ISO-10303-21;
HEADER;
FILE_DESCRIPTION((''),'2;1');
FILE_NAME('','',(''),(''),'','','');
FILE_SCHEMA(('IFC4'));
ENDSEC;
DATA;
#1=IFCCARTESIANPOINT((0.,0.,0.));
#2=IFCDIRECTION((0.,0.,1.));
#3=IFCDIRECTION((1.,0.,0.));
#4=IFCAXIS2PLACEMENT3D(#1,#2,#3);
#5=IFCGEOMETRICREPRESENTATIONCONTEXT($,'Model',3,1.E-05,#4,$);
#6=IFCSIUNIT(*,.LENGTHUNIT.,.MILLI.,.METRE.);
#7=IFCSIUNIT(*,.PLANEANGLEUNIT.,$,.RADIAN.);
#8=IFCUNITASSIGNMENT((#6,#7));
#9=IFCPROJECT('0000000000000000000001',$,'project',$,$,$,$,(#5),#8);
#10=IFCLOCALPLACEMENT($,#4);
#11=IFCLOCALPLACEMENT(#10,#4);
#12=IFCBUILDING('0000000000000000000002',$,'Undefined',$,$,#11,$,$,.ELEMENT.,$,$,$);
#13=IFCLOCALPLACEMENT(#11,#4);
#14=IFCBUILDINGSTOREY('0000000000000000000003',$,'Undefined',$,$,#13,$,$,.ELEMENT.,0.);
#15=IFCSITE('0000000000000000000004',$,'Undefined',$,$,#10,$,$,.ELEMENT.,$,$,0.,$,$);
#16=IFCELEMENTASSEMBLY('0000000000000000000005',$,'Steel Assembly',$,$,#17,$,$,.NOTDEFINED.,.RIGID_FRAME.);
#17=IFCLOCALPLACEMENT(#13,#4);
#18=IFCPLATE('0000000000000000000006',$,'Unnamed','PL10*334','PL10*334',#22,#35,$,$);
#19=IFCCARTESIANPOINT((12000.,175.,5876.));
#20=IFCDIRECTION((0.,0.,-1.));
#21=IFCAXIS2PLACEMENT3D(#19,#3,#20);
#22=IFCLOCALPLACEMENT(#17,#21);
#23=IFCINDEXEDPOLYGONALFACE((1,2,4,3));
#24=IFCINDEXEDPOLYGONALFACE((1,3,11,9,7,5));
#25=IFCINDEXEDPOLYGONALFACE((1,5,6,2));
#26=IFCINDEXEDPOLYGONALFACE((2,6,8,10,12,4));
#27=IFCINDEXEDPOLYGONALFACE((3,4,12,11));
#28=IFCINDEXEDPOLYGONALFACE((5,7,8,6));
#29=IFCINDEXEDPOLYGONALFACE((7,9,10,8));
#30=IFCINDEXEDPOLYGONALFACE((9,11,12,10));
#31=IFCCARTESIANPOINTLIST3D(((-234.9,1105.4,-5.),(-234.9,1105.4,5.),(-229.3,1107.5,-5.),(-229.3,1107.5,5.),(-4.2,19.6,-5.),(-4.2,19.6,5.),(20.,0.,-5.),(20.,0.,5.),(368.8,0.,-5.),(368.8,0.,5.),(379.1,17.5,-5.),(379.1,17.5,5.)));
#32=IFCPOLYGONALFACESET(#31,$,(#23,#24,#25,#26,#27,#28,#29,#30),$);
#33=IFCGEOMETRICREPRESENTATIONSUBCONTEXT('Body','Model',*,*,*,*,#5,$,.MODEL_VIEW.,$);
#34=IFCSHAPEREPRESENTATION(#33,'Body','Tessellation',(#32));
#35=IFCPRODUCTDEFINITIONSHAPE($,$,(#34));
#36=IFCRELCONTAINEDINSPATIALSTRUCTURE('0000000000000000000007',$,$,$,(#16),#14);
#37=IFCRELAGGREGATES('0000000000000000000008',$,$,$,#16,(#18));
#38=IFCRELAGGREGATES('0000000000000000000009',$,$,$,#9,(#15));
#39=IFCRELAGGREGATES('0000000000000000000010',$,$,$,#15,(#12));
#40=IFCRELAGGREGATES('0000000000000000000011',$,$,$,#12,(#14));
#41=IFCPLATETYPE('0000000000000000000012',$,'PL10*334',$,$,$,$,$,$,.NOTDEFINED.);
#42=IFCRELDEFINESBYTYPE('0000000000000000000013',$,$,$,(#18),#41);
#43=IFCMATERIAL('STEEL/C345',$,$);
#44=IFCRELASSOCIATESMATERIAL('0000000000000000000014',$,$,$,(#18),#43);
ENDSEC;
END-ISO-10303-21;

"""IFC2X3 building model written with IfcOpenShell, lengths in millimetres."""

from ifc_helpers import new_model, si_unit, frame, origin_with_axes, place, context, subcontext, project, spatial, polyline, outline, extrude, material, type_object, element, aggregate, save


model = new_model("IFC2X3")

# Units and contexts
model_context = context("Model", 3, precision=1e-05, world=origin_with_axes())
body_context = subcontext(model_context, "Body", "Model", "MODEL_VIEW")
ifc_project = project(units=[si_unit("LENGTHUNIT", "METRE", prefix="MILLI"), si_unit("PLANEANGLEUNIT", "RADIAN")], contexts=[model_context])

# Site, building, storey
site_placement = place(None, origin_with_axes())
site = spatial("IfcSite", under=ifc_project, at=site_placement, Name="Undefined", CompositionType="ELEMENT", RefElevation=0.0)
building_placement = place(site_placement, origin_with_axes())
building = spatial("IfcBuilding", under=site, at=building_placement, Name="Undefined", CompositionType="ELEMENT")
storey_placement = place(building_placement, origin_with_axes())
storey = spatial("IfcBuildingStorey", under=building, at=storey_placement, Name="Undefined", CompositionType="ELEMENT", Elevation=0.0)

# Shared definitions
ifc_material = material(Name="STEEL/C345")

# Element assembly, plate
assembly_1_placement = place(storey_placement, origin_with_axes())
assembly_1 = element("IfcElementAssembly", 1, at=assembly_1_placement, inside=storey, Name="Steel Assembly", AssemblyPlace="NOTDEFINED", PredefinedType="RIGID_FRAME")
plate_type_1 = type_object("IfcPlateType", Name="PL10*334", PredefinedType="NOTDEFINED")
plate_1_placement = place(assembly_1_placement, frame((12000.0, 175.0, 5876.0), z_axis=(1.0, 0.0, 0.0), x_axis=(0.0, 0.0, -1.0)))
plate_1 = element("IfcPlate", 2, at=plate_1_placement, type_object=plate_type_1, material=ifc_material, Name="Unnamed", Description="PL10*334", ObjectType="PL10*334", context=body_context, shape_type="SweptSolid", body=[
    extrude(outline(polyline([(-4.2, 19.6), (20.0, 0.0), (368.8, 0.0), (379.1, 17.5), (-229.3, 1107.5), (-234.9, 1105.4), (-4.2, 19.6)])), frame((0.0, 0.0, -5.0), z_axis=(0.0, 0.0, 1.0), x_axis=(1.0, 0.0, 0.0)), (0.0, 0.0, 1.0), 10.0),
])
aggregate(assembly_1, [plate_1])

save(model, "model.ifc")
